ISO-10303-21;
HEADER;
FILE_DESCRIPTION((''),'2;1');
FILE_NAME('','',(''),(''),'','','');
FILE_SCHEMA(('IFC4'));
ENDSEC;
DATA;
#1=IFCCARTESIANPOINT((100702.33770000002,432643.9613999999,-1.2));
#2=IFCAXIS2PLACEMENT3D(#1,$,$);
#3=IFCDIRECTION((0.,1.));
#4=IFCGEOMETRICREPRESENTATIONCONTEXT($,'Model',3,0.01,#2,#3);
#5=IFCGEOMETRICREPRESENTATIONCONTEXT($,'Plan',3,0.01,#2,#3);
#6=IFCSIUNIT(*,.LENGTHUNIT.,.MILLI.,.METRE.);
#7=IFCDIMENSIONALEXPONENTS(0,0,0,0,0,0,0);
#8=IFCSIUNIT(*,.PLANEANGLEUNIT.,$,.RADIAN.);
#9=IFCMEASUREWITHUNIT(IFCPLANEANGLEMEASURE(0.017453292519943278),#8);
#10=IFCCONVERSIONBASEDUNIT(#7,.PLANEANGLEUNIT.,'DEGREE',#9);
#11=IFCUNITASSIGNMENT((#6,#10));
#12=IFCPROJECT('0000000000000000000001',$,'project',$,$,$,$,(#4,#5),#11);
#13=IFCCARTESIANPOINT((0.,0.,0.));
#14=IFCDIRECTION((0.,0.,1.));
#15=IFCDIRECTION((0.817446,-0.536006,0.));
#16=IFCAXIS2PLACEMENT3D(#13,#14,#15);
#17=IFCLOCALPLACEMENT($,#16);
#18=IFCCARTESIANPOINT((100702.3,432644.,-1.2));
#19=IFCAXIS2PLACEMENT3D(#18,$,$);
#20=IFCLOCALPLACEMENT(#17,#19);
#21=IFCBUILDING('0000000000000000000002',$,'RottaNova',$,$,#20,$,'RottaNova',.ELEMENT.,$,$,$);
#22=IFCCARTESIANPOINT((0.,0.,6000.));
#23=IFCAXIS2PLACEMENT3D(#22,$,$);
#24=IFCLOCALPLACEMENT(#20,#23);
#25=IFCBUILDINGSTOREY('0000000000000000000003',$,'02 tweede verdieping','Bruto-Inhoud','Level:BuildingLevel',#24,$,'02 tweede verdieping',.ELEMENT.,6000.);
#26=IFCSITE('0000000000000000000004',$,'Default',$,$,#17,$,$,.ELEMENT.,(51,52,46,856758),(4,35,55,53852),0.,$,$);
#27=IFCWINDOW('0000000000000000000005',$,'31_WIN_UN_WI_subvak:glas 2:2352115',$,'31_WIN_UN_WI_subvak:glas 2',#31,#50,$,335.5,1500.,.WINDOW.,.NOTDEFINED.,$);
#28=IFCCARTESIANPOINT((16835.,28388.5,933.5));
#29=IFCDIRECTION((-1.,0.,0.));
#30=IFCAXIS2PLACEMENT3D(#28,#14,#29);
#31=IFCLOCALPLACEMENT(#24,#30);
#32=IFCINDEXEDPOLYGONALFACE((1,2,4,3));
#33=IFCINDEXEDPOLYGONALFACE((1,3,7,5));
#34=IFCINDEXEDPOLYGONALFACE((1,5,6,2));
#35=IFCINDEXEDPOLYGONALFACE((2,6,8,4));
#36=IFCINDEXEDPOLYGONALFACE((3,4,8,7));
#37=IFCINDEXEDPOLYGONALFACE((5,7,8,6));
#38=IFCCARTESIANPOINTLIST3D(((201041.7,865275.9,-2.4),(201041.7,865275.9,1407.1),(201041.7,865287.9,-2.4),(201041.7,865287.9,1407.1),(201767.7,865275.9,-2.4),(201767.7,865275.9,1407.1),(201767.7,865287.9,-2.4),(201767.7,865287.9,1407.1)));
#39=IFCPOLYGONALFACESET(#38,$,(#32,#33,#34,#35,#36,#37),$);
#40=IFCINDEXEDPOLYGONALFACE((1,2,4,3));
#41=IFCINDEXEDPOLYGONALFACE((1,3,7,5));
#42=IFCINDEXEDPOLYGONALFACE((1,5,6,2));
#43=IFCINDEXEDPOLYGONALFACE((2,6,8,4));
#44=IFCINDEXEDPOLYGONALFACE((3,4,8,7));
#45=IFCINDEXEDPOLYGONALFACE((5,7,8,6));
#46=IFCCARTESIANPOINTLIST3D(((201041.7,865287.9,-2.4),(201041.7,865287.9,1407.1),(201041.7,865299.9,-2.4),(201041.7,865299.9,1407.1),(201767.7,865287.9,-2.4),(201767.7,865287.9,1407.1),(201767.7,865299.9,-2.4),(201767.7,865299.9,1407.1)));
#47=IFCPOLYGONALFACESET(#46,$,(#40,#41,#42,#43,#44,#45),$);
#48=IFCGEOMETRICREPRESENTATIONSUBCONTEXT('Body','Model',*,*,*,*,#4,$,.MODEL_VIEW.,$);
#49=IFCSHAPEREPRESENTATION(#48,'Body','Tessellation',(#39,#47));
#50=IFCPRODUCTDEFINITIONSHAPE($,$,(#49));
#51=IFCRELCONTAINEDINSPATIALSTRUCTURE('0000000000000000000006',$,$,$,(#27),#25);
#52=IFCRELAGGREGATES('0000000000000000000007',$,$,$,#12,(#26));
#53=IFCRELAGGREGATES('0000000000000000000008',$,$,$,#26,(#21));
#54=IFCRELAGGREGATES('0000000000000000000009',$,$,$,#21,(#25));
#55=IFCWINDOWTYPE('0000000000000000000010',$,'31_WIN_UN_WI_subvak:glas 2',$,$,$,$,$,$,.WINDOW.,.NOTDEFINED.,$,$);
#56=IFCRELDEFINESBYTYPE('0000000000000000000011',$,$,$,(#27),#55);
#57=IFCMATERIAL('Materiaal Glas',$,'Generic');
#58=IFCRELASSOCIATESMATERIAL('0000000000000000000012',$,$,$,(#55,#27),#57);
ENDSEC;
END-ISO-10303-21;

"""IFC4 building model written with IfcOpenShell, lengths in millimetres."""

from ifc_helpers import new_model, entity, si_unit, converted_unit, direction, frame, place, context, subcontext, project, spatial, indexed_curve, outline, extrude, source, transform, mapped, material, type_object, type_shapes, element, save


model = new_model("IFC4")

# Units and contexts
model_context = context("Model", 3, precision=0.01, world=frame((100702.33770000002, 432643.9613999999, -1.2)), true_north=direction((0.0, 1.0)))
plan_context = context("Plan", 3, precision=0.01, world=frame((100702.33770000002, 432643.9613999999, -1.2)), true_north=direction((0.0, 1.0)))
body_context = subcontext(model_context, "Body", "Model", "MODEL_VIEW")
ifc_project = project(units=[si_unit("LENGTHUNIT", "METRE", prefix="MILLI"), converted_unit("PLANEANGLEUNIT", "DEGREE", entity("IfcPlaneAngleMeasure", 0.017453292519943278), si_unit("PLANEANGLEUNIT", "RADIAN"), dimensions=[0, 0, 0, 0, 0, 0, 0])], contexts=[model_context, plan_context])

# Site, building, storey
site_placement = place(None, frame((0.0, 0.0, 0.0), z_axis=(0.0, 0.0, 1.0), x_axis=(0.817446, -0.536006, 0.0)))
site = spatial("IfcSite", under=ifc_project, at=site_placement, Name="Default", CompositionType="ELEMENT", RefLatitude=(51, 52, 46, 856758), RefLongitude=(4, 35, 55, 53852), RefElevation=0.0)
building_placement = place(site_placement, frame((100702.3, 432644.0, -1.2)))
building = spatial("IfcBuilding", under=site, at=building_placement, Name="RottaNova", LongName="RottaNova", CompositionType="ELEMENT")
storey_placement = place(building_placement, frame((0.0, 0.0, 6000.0)))
storey = spatial("IfcBuildingStorey", under=building, at=storey_placement, Name="02 tweede verdieping", Description="Bruto-Inhoud", ObjectType="Level:BuildingLevel", LongName="02 tweede verdieping", CompositionType="ELEMENT", Elevation=6000.0)

# Shared definitions
ifc_material_1 = material(Name="Materiaal Glas", Category="Generic")

# Window
window_type = type_object("IfcWindowType", Name="31_WIN_UN_WI_subvak:glas 2", PartitioningType="NOTDEFINED", PredefinedType="WINDOW", material=ifc_material_1)
shared_shape_1 = source(frame((100702.3, 432644.0, -1.2)), body_context, "Body", "SweptSolid", [
    extrude(outline(indexed_curve([(-363.0, -6.0), (363.0, -6.0), (363.0, 6.0), (-363.0, 6.0), (-363.0, -6.0)], self_intersect=False)), frame((0.0, -6.0, 0.0)), (0.0, 0.0, 1.0), 1409.5),
    extrude(outline(indexed_curve([(-363.0, -6.0), (363.0, -6.0), (363.0, 6.0), (-363.0, 6.0), (-363.0, -6.0)], self_intersect=False)), frame((0.0, 6.0, 0.0)), (0.0, 0.0, 1.0), 1409.5),
])
type_shapes(window_type, [shared_shape_1])
window_1_placement = place(storey_placement, frame((16835.0, 28388.5, 933.5), z_axis=(0.0, 0.0, 1.0), x_axis=(-1.0, 0.0, 0.0)))
element("IfcWindow", 1, at=window_1_placement, inside=storey, type_object=window_type, material=ifc_material_1, Name="31_WIN_UN_WI_subvak:glas 2:2352115", ObjectType="31_WIN_UN_WI_subvak:glas 2", OverallHeight=335.5, OverallWidth=1500.0, PartitioningType="NOTDEFINED", PredefinedType="WINDOW", context=body_context, shape_type="MappedRepresentation", body=[
    mapped(shared_shape_1, transform((100702.3, 432644.0, -1.2), scale=1.0)),
])

save(model, "model.ifc")
